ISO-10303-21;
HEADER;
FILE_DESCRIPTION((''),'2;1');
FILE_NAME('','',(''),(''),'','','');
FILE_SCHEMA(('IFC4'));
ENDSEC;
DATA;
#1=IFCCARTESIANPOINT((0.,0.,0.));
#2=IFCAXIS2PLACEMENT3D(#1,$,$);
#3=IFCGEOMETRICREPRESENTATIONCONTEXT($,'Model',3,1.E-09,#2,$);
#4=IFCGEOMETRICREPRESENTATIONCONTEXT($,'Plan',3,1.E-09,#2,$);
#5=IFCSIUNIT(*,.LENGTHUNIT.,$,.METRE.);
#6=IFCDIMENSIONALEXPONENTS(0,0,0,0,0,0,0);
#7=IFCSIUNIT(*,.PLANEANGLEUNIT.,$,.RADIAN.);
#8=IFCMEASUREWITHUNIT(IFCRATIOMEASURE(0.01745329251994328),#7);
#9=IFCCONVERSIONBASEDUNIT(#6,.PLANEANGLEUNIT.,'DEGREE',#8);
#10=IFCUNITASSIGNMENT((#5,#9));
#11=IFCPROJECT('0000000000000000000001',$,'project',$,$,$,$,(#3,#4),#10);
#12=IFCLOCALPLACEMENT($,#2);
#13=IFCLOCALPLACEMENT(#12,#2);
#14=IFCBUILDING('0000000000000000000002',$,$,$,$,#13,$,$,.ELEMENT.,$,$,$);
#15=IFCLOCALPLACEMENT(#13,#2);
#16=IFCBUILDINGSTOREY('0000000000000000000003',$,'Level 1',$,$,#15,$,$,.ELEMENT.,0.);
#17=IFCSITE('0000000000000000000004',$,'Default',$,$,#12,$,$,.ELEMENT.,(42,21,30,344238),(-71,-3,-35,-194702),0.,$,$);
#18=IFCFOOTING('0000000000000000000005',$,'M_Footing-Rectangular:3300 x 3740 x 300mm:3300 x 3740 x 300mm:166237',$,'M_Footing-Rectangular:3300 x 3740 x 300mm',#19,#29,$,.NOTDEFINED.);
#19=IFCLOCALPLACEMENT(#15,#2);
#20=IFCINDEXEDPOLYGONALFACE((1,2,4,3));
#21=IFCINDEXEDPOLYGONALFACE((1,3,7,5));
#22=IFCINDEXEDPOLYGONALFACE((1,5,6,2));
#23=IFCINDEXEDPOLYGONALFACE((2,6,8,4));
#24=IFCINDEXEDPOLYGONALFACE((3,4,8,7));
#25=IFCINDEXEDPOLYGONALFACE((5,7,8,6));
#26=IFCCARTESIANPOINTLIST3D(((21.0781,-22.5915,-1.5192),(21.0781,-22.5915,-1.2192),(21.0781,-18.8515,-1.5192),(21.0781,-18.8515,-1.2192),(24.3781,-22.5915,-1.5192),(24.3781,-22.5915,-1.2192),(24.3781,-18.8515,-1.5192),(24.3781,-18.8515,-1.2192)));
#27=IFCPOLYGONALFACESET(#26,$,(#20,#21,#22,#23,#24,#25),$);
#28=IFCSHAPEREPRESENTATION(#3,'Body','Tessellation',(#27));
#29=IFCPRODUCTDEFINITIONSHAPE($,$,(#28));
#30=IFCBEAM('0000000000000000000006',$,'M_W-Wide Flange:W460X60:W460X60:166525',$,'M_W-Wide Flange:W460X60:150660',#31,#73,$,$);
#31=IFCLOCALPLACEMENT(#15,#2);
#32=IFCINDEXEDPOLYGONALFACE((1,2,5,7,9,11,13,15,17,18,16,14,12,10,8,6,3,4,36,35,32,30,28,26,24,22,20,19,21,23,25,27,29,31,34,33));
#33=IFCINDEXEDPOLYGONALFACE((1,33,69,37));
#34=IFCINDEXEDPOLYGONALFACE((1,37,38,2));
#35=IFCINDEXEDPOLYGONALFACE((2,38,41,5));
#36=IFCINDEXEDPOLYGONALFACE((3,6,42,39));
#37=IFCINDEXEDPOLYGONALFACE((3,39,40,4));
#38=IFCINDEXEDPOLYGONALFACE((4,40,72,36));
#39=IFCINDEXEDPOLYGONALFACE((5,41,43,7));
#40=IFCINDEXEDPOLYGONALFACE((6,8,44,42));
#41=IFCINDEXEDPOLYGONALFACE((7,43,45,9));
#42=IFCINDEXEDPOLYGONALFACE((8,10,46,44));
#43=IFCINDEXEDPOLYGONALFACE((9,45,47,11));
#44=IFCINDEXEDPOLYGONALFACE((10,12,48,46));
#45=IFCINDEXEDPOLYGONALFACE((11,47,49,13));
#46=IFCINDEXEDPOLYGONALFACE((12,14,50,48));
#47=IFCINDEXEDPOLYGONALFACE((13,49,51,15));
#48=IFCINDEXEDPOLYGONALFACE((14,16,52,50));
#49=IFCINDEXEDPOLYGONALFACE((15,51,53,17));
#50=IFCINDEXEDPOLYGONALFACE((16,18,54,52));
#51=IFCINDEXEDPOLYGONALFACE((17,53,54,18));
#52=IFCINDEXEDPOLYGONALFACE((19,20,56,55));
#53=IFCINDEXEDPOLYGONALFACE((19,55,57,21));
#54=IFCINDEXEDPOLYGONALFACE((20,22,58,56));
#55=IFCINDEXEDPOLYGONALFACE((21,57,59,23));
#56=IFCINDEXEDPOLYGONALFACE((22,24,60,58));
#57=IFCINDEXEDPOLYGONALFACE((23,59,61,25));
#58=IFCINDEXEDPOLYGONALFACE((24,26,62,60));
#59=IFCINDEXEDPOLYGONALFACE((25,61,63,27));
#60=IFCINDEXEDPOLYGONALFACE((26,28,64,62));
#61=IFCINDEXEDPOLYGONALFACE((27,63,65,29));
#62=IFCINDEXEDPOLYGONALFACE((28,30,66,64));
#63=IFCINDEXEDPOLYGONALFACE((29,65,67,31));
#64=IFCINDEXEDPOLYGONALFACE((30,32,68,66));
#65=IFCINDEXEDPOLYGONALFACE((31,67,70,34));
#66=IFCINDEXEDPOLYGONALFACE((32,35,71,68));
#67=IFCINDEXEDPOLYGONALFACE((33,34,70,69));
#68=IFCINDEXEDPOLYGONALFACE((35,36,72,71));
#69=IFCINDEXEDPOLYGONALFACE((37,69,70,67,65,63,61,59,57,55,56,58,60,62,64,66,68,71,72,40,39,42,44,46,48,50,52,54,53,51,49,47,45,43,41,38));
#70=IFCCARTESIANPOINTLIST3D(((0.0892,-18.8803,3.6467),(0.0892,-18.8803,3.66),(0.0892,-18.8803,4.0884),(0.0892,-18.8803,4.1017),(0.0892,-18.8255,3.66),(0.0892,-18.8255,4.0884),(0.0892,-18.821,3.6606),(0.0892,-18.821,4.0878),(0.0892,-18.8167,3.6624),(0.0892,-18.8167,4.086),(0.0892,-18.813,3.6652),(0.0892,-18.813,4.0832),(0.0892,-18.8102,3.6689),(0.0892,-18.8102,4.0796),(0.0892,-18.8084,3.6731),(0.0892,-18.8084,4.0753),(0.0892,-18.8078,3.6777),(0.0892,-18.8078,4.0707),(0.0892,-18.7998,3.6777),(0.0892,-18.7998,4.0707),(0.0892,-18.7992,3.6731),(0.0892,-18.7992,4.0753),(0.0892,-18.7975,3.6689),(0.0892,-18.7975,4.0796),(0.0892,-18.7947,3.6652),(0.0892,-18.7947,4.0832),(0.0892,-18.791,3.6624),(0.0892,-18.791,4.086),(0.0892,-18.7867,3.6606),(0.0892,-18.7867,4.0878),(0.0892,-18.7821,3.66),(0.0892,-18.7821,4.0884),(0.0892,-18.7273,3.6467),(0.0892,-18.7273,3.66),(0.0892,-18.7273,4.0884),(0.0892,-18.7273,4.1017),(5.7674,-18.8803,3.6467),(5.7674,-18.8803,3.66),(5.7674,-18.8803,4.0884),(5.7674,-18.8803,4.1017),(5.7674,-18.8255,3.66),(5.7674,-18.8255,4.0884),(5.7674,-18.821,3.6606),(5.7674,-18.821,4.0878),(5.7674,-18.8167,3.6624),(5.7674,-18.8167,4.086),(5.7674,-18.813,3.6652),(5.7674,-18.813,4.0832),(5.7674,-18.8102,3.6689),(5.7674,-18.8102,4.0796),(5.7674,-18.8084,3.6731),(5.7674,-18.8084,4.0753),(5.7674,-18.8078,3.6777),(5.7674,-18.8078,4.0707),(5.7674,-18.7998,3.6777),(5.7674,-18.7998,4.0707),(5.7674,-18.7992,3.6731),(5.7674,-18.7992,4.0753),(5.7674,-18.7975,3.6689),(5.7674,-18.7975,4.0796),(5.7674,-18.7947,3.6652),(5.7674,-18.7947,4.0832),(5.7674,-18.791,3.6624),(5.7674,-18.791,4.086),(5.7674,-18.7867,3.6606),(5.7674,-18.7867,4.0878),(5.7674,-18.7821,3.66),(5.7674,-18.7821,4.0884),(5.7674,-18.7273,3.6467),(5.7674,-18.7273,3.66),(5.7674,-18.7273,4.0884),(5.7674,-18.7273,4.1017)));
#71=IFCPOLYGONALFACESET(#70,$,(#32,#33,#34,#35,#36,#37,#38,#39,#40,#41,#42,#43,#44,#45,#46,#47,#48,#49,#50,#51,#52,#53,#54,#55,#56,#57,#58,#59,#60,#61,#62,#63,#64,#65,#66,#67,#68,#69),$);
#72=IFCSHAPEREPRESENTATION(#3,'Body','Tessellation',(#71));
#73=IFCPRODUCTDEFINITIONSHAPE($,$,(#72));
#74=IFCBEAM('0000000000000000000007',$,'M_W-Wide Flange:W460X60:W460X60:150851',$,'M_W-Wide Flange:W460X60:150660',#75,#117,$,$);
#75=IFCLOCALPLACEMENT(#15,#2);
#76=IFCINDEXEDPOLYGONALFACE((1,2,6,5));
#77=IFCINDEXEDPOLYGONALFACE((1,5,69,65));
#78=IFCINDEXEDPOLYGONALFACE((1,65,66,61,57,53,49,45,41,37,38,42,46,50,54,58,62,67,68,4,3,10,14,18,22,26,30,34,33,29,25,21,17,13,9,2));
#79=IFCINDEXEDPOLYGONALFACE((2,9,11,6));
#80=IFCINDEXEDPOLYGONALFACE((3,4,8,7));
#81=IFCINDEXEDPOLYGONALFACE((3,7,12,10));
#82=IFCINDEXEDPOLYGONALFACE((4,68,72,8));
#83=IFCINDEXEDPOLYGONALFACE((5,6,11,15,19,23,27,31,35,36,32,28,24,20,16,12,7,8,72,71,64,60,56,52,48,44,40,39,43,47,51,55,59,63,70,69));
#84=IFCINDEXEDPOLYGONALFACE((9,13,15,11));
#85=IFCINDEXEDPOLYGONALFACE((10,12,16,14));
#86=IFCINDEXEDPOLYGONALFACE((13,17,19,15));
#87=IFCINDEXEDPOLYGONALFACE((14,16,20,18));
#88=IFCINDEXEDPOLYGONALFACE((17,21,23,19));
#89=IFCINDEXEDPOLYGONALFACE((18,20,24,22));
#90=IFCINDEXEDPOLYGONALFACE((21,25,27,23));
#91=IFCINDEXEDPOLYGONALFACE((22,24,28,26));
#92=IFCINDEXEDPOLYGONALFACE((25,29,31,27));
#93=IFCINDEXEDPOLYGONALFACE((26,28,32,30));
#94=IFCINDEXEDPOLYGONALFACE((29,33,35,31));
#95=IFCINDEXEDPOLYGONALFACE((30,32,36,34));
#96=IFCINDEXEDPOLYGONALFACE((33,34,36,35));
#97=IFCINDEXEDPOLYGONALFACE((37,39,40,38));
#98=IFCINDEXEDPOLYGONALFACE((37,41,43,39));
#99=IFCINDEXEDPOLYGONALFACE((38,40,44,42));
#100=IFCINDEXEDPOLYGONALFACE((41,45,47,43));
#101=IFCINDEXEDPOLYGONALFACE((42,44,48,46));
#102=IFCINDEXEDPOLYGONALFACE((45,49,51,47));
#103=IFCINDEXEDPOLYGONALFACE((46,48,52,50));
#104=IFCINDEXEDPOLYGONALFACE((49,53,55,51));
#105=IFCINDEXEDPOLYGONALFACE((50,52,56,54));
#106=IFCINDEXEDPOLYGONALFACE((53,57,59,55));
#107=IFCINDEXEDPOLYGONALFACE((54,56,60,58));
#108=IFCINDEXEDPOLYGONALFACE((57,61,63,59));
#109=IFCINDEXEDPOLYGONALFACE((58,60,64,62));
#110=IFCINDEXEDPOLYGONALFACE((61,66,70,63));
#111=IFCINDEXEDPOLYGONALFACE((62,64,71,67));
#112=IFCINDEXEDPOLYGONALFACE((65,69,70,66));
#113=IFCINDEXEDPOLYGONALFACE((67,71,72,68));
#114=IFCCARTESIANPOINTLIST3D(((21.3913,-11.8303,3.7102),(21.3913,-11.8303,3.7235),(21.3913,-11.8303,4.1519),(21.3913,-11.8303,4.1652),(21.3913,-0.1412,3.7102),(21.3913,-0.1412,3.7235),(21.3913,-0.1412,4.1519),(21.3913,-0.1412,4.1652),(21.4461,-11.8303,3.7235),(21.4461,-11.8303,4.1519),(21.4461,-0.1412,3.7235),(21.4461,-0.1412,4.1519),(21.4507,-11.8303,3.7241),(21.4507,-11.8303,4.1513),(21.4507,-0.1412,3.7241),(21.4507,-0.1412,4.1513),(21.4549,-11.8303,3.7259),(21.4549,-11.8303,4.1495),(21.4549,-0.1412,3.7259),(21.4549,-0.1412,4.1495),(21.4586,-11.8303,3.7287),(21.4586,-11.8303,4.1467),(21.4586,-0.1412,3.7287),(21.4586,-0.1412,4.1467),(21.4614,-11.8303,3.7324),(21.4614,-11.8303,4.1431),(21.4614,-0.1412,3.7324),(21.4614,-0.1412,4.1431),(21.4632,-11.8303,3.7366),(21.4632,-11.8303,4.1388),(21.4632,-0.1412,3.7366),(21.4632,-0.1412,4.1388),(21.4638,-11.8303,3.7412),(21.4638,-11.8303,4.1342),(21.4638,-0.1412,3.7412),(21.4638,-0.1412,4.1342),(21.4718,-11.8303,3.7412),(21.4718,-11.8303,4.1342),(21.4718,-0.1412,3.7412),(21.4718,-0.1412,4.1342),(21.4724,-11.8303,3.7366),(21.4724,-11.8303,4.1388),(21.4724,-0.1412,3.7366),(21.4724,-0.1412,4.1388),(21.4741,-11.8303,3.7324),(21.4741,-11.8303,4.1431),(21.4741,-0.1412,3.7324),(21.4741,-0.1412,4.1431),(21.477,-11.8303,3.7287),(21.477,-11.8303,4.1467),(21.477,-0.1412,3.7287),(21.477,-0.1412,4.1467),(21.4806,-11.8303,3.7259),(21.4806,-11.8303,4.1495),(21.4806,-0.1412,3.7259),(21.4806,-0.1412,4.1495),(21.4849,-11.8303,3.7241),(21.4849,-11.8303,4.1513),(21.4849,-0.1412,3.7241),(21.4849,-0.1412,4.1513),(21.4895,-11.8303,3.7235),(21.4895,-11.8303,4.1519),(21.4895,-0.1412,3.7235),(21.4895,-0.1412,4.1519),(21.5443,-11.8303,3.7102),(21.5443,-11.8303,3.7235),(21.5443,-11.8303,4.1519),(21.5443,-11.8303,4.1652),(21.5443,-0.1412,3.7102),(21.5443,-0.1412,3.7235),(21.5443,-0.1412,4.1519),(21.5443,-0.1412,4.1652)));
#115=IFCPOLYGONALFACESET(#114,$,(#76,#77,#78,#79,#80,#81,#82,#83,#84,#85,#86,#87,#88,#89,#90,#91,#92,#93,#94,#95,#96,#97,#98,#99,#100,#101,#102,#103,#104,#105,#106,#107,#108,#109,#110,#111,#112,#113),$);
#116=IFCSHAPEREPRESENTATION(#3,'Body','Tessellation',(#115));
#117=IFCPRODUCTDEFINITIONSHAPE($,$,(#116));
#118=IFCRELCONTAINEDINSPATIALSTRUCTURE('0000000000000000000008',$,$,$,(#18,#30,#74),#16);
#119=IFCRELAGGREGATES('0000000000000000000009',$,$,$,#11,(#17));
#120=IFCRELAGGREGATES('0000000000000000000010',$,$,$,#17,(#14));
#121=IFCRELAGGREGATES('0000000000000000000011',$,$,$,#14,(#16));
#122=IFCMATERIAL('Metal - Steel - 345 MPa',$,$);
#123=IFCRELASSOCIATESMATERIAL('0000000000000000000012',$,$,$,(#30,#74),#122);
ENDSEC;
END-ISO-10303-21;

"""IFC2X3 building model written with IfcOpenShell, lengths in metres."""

from ifc_helpers import new_model, entity, si_unit, converted_unit, frame, frame_2d, origin, origin_2d_with_axis, place, context, project, spatial, polyline, circle_curve, parameter, trimmed, segment, composite_curve, rectangle, outline, extrude, material, element, save


model = new_model("IFC2X3")

# Units and contexts
model_context = context("Model", 3, precision=1e-09, world=origin())
plan_context = context("Plan", 3, precision=1e-09, world=origin())
ifc_project = project(units=[si_unit("LENGTHUNIT", "METRE"), converted_unit("PLANEANGLEUNIT", "DEGREE", entity("IfcRatioMeasure", 0.01745329251994328), si_unit("PLANEANGLEUNIT", "RADIAN"), dimensions=[0, 0, 0, 0, 0, 0, 0])], contexts=[model_context, plan_context])

# Site, building, storey
site_placement = place(None, origin())
site = spatial("IfcSite", under=ifc_project, at=site_placement, Name="Default", CompositionType="ELEMENT", RefLatitude=(42, 21, 30, 344238), RefLongitude=(-71, -3, -35, -194702), RefElevation=0.0)
building_placement = place(site_placement, origin())
building = spatial("IfcBuilding", under=site, at=building_placement, CompositionType="ELEMENT")
storey_placement = place(building_placement, origin())
storey = spatial("IfcBuildingStorey", under=building, at=storey_placement, Name="Level 1", CompositionType="ELEMENT", Elevation=0.0)

# Footing
footing_placement = place(storey_placement, origin())
element("IfcFooting", 1, at=footing_placement, inside=storey, Name="M_Footing-Rectangular:3300 x 3740 x 300mm:3300 x 3740 x 300mm:166237", ObjectType="M_Footing-Rectangular:3300 x 3740 x 300mm", PredefinedType="NOTDEFINED", context=model_context, shape_type="SweptSolid", body=[
    extrude(rectangle(XDim=3.3, YDim=3.74, at=origin_2d_with_axis()), frame((22.7281, -20.7215, -1.5192), z_axis=(0.0, 0.0, 1.0), x_axis=(-1.0, 0.0, 0.0)), (0.0, 0.0, 1.0), 0.3),
])

# Beams
ifc_material_1 = material(Name="Metal - Steel - 345 MPa")
beam_1_placement = place(storey_placement, frame((5.8566, -18.8038, 4.2672), z_axis=(0.0, 0.0, 1.0), x_axis=(0.0, 1.0, 0.0)))
element("IfcBeam", 2, at=beam_1_placement, inside=storey, material=ifc_material_1, Name="M_W-Wide Flange:W460X60:W460X60:166525", ObjectType="M_W-Wide Flange:W460X60:150660", context=model_context, shape_type="SweptSolid", body=[
    extrude(outline(composite_curve([segment(polyline([(0.2142, -0.0765), (0.2275, -0.0765)]), True, "CONTINUOUS"), segment(polyline([(0.2275, -0.0765), (0.2275, 0.0765)]), True, "CONTINUOUS"), segment(polyline([(0.2275, 0.0765), (0.2142, 0.0765)]), True, "CONTINUOUS"), segment(polyline([(0.2142, 0.0765), (0.2142, 0.0217)]), True, "CONTINUOUS"), segment(trimmed(circle_curve(frame_2d((0.1965, 0.0217), x_axis=(0.0, 1.0)), 0.0177), [parameter(180.0)], [parameter(270.0)], True, "PARAMETER"), False, "CONTINUOUS"), segment(polyline([(0.1965, 0.004), (-0.1965, 0.004)]), True, "CONTINUOUS"), segment(trimmed(circle_curve(frame_2d((-0.1965, 0.0217), x_axis=(0.0, 1.0)), 0.0177), [parameter(90.0)], [parameter(180.0)], True, "PARAMETER"), False, "CONTINUOUS"), segment(polyline([(-0.2142, 0.0217), (-0.2142, 0.0765)]), True, "CONTINUOUS"), segment(polyline([(-0.2142, 0.0765), (-0.2275, 0.0765)]), True, "CONTINUOUS"), segment(polyline([(-0.2275, 0.0765), (-0.2275, -0.0765)]), True, "CONTINUOUS"), segment(polyline([(-0.2275, -0.0765), (-0.2142, -0.0765)]), True, "CONTINUOUS"), segment(polyline([(-0.2142, -0.0765), (-0.2142, -0.0217)]), True, "CONTINUOUS"), segment(trimmed(circle_curve(frame_2d((-0.1965, -0.0217), x_axis=(0.0, 1.0)), 0.0177), [parameter(360.0)], [parameter(90.0)], True, "PARAMETER"), False, "CONTINUOUS"), segment(polyline([(-0.1965, -0.004), (0.1965, -0.004)]), True, "CONTINUOUS"), segment(trimmed(circle_curve(frame_2d((0.1965, -0.0217), x_axis=(0.0, 1.0)), 0.0177), [parameter(270.0)], [parameter(0.0)], True, "PARAMETER"), False, "CONTINUOUS"), segment(polyline([(0.2142, -0.0217), (0.2142, -0.0765)]), True, "CONTINUOUS")], self_intersect=False)), frame((0.0, 5.7674, -0.393), z_axis=(0.0, -1.0, 0.0), x_axis=(0.0, 0.0, -1.0)), (0.0, 0.0, 1.0), 5.6782),
])
beam_2_placement = place(storey_placement, frame((21.4678, 0.0, 4.2672), z_axis=(0.0, 0.0, 1.0), x_axis=(-1.0, 0.0, 0.0)))
element("IfcBeam", 3, at=beam_2_placement, inside=storey, material=ifc_material_1, Name="M_W-Wide Flange:W460X60:W460X60:150851", ObjectType="M_W-Wide Flange:W460X60:150660", context=model_context, shape_type="SweptSolid", body=[
    extrude(outline(composite_curve([segment(polyline([(0.2142, -0.0765), (0.2275, -0.0765)]), True, "CONTINUOUS"), segment(polyline([(0.2275, -0.0765), (0.2275, 0.0765)]), True, "CONTINUOUS"), segment(polyline([(0.2275, 0.0765), (0.2142, 0.0765)]), True, "CONTINUOUS"), segment(polyline([(0.2142, 0.0765), (0.2142, 0.0217)]), True, "CONTINUOUS"), segment(trimmed(circle_curve(frame_2d((0.1965, 0.0217), x_axis=(0.0, 1.0)), 0.0177), [parameter(180.0)], [parameter(270.0)], True, "PARAMETER"), False, "CONTINUOUS"), segment(polyline([(0.1965, 0.004), (-0.1965, 0.004)]), True, "CONTINUOUS"), segment(trimmed(circle_curve(frame_2d((-0.1965, 0.0217), x_axis=(0.0, 1.0)), 0.0177), [parameter(90.0)], [parameter(180.0)], True, "PARAMETER"), False, "CONTINUOUS"), segment(polyline([(-0.2142, 0.0217), (-0.2142, 0.0765)]), True, "CONTINUOUS"), segment(polyline([(-0.2142, 0.0765), (-0.2275, 0.0765)]), True, "CONTINUOUS"), segment(polyline([(-0.2275, 0.0765), (-0.2275, -0.0765)]), True, "CONTINUOUS"), segment(polyline([(-0.2275, -0.0765), (-0.2142, -0.0765)]), True, "CONTINUOUS"), segment(polyline([(-0.2142, -0.0765), (-0.2142, -0.0217)]), True, "CONTINUOUS"), segment(trimmed(circle_curve(frame_2d((-0.1965, -0.0217), x_axis=(0.0, 1.0)), 0.0177), [parameter(360.0)], [parameter(90.0)], True, "PARAMETER"), False, "CONTINUOUS"), segment(polyline([(-0.1965, -0.004), (0.1965, -0.004)]), True, "CONTINUOUS"), segment(trimmed(circle_curve(frame_2d((0.1965, -0.0217), x_axis=(0.0, 1.0)), 0.0177), [parameter(270.0)], [parameter(0.0)], True, "PARAMETER"), False, "CONTINUOUS"), segment(polyline([(0.2142, -0.0217), (0.2142, -0.0765)]), True, "CONTINUOUS")], self_intersect=False)), frame((0.0, 11.8303, -0.3295), z_axis=(0.0, -1.0, 0.0), x_axis=(0.0, 0.0, -1.0)), (0.0, 0.0, 1.0), 11.6891),
])

save(model, "model.ifc")
